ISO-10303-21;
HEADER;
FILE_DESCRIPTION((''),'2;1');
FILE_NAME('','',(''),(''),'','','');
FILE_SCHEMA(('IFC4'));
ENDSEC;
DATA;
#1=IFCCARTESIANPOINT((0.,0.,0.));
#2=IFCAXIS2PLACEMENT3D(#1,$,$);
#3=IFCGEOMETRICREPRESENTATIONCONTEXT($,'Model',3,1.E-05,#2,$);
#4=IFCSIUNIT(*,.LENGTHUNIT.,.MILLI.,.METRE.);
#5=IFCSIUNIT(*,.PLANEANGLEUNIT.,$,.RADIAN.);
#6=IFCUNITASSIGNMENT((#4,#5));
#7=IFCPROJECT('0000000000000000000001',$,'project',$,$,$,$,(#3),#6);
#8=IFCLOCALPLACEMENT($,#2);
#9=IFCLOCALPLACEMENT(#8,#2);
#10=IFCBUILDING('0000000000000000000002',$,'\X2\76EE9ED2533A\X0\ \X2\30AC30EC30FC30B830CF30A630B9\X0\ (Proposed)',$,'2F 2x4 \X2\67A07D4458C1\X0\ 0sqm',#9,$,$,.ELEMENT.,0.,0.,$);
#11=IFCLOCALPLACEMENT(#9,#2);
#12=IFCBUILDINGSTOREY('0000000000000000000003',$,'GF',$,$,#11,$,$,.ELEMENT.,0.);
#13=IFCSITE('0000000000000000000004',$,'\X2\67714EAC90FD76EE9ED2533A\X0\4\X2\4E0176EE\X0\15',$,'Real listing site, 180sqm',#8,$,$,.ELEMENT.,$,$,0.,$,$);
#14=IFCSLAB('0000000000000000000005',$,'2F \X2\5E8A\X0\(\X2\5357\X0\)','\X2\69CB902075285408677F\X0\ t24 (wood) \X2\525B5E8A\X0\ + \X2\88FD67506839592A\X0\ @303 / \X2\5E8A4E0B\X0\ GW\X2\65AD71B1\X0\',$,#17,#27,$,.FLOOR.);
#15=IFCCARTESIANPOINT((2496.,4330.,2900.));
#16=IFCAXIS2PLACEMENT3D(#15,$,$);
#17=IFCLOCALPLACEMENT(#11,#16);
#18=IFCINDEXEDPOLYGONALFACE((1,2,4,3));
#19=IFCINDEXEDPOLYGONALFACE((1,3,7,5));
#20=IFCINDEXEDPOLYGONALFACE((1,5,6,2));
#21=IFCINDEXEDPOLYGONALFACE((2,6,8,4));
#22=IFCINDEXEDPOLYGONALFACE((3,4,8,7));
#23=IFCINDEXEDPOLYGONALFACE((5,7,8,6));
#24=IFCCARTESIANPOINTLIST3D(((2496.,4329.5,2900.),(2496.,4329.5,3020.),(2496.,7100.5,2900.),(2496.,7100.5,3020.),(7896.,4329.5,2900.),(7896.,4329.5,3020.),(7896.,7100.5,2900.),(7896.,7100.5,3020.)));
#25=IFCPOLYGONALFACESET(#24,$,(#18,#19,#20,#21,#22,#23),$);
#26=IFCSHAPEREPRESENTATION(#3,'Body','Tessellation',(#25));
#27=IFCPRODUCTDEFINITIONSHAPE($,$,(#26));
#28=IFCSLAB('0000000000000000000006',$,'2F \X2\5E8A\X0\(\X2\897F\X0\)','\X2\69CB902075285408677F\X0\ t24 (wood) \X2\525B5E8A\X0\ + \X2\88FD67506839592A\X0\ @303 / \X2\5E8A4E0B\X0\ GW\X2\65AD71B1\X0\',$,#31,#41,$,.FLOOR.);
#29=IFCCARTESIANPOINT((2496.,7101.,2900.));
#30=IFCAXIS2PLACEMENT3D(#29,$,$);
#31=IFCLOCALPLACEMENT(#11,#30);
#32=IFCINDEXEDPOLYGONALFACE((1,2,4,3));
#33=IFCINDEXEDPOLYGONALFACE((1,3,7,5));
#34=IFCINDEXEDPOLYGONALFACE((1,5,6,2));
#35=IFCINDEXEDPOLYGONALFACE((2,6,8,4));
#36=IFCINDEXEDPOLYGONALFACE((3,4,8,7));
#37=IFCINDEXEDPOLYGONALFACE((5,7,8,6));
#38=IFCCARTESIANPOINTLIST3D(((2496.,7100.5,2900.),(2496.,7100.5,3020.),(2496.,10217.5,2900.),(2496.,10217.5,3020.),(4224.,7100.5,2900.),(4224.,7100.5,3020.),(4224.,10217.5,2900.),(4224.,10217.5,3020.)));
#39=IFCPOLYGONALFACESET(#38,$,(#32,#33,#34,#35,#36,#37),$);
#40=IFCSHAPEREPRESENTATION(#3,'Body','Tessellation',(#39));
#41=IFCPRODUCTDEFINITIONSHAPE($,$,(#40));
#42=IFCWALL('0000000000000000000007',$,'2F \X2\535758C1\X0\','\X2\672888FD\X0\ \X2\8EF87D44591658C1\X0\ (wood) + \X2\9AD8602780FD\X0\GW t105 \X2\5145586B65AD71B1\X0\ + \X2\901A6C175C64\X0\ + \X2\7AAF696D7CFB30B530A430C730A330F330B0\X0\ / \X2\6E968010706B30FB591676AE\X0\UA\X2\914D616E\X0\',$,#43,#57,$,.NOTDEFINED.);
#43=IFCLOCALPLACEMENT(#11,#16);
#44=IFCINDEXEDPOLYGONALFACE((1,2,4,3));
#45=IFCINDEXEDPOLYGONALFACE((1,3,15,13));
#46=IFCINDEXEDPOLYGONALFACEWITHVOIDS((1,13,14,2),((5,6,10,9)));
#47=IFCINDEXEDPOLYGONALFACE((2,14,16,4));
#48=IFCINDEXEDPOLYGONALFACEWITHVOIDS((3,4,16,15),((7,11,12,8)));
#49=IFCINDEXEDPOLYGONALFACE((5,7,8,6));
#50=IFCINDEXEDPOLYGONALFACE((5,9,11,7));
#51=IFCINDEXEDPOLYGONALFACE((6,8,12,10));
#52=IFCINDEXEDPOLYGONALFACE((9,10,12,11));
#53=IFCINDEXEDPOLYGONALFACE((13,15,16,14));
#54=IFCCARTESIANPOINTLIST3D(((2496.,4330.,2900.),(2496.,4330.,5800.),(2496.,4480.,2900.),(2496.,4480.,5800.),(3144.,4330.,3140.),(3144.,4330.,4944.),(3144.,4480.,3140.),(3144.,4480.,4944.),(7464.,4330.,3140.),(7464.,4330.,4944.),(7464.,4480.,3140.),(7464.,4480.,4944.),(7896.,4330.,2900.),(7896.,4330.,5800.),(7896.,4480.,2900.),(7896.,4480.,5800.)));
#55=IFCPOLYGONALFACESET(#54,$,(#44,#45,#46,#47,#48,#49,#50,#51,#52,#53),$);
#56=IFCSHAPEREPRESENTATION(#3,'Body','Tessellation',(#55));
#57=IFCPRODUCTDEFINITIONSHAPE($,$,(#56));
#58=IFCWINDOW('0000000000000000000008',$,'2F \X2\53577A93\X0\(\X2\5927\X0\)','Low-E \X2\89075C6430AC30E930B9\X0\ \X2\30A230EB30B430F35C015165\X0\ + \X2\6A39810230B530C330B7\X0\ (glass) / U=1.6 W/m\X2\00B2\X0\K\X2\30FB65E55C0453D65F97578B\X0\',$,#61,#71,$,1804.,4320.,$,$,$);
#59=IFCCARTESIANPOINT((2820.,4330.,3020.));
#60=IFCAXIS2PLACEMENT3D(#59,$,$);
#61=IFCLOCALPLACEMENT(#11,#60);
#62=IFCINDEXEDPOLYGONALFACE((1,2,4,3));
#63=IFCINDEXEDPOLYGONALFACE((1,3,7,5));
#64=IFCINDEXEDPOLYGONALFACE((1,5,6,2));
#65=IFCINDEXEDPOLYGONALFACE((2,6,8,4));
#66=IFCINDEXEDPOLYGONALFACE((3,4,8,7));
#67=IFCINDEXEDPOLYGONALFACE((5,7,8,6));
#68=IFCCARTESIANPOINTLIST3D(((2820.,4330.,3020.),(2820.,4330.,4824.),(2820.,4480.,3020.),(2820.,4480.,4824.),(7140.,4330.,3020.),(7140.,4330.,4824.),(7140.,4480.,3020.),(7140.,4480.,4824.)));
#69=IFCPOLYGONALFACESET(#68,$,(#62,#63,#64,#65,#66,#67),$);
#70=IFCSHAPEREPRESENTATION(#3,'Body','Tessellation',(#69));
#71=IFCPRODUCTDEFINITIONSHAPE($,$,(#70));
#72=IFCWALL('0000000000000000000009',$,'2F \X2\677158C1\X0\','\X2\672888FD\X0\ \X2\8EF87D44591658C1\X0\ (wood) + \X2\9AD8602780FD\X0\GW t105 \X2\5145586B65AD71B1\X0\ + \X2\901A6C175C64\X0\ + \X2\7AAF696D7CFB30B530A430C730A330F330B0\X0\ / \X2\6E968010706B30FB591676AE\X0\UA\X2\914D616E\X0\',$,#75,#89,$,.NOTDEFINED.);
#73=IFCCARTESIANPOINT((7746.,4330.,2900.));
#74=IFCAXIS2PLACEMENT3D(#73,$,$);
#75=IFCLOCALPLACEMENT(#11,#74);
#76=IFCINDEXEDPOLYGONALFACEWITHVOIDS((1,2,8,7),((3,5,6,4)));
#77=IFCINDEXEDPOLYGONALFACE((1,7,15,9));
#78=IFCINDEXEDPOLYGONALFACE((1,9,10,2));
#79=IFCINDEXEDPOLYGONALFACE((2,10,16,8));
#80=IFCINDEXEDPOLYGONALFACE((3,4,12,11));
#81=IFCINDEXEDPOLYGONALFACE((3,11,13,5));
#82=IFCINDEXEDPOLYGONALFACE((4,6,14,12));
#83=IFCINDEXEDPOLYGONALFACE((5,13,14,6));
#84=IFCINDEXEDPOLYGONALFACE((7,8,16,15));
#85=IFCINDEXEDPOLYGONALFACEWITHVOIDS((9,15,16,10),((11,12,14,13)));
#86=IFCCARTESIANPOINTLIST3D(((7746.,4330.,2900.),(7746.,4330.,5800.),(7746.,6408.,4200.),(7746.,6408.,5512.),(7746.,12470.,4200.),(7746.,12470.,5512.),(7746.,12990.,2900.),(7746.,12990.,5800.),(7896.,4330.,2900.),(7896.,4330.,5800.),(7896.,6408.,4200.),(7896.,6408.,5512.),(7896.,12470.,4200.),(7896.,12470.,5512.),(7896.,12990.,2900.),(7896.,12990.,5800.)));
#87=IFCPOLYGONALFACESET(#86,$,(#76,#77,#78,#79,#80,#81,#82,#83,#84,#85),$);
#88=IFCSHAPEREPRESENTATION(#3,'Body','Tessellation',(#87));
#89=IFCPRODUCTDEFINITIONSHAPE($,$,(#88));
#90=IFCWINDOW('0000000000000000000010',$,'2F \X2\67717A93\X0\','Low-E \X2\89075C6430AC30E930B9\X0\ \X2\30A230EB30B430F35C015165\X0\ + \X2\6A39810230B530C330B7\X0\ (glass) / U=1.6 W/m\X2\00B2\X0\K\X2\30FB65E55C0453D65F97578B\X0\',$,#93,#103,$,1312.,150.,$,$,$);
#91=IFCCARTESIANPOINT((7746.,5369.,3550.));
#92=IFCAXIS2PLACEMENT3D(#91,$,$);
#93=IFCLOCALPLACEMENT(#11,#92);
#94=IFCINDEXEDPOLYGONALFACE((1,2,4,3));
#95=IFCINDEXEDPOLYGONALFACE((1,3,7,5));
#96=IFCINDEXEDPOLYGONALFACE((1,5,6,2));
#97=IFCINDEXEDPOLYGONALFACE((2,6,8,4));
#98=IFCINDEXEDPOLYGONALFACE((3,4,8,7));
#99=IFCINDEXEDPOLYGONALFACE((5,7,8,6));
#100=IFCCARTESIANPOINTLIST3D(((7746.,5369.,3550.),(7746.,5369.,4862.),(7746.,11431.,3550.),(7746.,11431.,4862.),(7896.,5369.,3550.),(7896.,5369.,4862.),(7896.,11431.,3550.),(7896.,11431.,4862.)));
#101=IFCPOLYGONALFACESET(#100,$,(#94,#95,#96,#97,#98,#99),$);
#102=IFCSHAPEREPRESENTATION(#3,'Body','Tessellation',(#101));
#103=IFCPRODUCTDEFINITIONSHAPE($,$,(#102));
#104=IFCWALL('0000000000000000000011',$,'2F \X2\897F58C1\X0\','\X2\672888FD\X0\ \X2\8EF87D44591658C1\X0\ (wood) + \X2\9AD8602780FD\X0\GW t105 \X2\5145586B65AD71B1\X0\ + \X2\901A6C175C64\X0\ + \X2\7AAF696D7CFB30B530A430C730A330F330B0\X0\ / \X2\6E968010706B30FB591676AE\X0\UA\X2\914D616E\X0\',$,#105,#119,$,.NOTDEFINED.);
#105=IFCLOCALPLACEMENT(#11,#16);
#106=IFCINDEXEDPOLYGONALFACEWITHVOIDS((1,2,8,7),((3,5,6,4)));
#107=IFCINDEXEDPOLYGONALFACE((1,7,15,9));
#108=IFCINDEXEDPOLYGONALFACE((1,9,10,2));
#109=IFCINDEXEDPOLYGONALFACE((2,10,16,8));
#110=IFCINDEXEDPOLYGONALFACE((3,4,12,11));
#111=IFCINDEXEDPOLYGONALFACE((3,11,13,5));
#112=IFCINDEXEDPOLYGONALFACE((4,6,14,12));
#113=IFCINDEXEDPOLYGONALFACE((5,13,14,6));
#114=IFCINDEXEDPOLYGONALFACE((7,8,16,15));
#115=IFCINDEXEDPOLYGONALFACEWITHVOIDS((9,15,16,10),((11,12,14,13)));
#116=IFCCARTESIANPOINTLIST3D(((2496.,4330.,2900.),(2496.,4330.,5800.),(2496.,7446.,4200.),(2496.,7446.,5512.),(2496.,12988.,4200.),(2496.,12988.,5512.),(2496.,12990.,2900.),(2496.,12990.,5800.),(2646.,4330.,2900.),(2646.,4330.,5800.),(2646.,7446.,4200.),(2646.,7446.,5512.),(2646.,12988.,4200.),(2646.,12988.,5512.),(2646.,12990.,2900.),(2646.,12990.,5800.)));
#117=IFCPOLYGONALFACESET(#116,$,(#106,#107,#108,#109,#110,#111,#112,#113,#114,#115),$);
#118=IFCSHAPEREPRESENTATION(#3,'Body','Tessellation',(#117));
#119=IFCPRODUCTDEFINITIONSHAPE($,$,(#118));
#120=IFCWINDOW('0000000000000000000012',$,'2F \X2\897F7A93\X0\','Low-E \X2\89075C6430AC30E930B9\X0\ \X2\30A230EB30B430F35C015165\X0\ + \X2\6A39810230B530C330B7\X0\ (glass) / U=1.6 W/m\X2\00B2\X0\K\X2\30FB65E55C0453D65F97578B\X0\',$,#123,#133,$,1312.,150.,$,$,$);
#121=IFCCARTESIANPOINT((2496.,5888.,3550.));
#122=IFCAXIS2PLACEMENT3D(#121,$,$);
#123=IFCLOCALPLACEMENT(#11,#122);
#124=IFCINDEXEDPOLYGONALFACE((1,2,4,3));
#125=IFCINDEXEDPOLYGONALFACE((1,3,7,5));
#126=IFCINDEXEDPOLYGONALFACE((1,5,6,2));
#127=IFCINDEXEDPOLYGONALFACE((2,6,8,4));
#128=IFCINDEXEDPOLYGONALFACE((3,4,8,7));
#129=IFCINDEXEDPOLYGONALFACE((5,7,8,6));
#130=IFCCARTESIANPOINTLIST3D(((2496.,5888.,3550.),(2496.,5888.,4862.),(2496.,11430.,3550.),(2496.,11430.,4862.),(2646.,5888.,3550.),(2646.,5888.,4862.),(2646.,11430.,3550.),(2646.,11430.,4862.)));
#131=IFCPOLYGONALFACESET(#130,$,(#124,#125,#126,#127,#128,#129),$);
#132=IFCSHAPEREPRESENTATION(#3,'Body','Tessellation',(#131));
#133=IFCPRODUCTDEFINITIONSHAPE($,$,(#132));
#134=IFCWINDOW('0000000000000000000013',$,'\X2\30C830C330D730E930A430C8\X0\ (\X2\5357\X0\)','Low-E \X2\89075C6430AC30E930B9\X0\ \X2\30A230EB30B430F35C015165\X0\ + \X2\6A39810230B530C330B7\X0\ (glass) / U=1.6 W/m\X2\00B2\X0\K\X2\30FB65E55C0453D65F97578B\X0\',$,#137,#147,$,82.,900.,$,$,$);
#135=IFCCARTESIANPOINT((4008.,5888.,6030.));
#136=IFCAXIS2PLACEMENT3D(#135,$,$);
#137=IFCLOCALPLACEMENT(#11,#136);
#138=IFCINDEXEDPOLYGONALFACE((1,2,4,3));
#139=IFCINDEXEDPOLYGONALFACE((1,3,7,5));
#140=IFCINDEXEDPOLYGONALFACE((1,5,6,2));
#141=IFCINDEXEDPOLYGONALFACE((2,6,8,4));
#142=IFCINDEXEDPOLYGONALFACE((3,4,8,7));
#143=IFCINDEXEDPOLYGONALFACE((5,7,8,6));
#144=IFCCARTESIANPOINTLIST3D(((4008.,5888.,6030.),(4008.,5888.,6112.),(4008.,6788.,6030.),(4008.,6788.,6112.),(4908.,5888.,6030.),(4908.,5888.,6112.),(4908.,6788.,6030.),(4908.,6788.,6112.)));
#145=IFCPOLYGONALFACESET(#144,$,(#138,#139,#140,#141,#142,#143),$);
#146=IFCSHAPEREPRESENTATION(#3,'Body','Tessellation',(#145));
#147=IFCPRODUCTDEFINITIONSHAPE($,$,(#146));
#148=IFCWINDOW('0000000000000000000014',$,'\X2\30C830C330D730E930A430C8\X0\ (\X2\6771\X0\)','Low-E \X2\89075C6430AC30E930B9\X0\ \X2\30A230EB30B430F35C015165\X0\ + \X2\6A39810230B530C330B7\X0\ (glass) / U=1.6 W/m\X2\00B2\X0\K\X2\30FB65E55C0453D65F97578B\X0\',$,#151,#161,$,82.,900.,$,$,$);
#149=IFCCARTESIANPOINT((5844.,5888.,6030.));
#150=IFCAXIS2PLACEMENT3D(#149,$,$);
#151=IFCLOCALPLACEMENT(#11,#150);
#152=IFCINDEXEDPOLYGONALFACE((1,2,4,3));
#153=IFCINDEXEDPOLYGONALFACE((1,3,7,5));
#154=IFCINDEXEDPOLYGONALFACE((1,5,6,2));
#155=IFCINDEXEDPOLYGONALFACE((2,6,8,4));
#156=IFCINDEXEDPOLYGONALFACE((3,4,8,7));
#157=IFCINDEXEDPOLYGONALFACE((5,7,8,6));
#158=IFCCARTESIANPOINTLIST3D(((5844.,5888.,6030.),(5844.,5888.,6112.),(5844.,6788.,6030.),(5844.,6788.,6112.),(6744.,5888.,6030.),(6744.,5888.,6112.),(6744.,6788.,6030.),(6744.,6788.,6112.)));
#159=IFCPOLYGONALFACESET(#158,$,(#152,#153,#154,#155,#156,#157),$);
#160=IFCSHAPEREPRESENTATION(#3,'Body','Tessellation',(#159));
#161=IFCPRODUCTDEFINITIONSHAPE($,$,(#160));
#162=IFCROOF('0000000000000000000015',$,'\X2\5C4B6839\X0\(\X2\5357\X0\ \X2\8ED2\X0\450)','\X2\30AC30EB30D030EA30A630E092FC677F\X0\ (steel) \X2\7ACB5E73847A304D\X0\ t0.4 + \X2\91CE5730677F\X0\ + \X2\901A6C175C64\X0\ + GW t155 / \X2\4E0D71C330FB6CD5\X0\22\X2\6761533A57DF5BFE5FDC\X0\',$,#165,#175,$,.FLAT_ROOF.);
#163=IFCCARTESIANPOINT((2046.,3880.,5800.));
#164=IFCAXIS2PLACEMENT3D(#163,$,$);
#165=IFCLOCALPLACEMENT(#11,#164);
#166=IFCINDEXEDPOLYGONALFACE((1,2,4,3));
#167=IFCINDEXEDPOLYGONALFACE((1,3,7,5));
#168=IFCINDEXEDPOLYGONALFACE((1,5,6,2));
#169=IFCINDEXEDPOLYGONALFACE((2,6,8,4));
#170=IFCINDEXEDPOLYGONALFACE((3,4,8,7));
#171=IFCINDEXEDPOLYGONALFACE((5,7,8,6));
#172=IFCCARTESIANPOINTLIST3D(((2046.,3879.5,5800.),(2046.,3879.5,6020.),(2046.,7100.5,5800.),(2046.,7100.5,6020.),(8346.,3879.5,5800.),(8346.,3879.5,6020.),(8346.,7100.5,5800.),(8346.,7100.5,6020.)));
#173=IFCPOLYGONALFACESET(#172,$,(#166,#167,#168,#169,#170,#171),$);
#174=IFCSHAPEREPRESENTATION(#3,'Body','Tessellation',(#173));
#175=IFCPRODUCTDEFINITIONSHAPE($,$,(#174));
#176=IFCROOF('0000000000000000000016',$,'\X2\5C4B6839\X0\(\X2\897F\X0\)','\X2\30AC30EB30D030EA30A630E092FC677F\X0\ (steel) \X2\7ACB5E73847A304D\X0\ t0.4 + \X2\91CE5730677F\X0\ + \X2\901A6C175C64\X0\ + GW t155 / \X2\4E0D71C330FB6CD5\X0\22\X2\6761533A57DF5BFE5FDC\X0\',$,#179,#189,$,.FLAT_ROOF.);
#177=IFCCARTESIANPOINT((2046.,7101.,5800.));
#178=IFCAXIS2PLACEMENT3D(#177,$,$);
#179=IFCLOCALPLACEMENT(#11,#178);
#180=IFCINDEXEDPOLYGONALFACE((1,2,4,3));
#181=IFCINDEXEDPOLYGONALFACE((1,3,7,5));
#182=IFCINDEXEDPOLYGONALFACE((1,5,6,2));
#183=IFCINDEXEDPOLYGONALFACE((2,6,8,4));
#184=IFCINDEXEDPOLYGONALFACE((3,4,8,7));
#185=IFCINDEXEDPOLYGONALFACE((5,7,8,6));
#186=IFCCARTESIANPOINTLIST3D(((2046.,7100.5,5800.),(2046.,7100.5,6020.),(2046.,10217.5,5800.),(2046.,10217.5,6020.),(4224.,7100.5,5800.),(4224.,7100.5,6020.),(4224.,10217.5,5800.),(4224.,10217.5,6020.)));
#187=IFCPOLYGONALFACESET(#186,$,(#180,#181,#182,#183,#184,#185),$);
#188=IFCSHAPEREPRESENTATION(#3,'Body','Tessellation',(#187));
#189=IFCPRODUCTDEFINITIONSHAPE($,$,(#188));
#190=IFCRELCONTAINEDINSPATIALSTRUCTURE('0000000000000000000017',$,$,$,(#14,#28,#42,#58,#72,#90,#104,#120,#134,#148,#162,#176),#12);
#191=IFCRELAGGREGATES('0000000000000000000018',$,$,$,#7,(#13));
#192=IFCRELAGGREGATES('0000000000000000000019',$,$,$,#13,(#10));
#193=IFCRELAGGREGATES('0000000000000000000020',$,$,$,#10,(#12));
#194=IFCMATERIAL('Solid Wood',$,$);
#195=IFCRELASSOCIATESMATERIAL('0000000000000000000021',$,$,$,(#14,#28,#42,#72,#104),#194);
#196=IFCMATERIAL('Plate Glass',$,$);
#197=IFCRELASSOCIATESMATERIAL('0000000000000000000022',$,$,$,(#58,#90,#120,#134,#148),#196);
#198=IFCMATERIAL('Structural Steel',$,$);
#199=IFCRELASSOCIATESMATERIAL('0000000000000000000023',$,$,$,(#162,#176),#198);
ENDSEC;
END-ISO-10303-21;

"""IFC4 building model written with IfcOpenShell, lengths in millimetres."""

from ifc_helpers import new_model, si_unit, frame, frame_2d, origin, place, context, project, spatial, rectangle, extrude, material, element, fill, save


model = new_model("IFC4")

# Units and contexts
model_context = context("Model", 3, precision=1e-05, world=origin())
ifc_project = project(units=[si_unit("LENGTHUNIT", "METRE", prefix="MILLI"), si_unit("PLANEANGLEUNIT", "RADIAN")], contexts=[model_context])

# Site, building, storey
site_placement = place(None, origin())
site = spatial("IfcSite", under=ifc_project, at=site_placement, Name="東京都目黒区4丁目15", ObjectType="Real listing site, 180sqm", CompositionType="ELEMENT", RefElevation=0.0)
building_placement = place(site_placement, origin())
building = spatial("IfcBuilding", under=site, at=building_placement, Name="目黒区 ガレージハウス (Proposed)", ObjectType="2F 2x4 枠組壁 0sqm", CompositionType="ELEMENT", ElevationOfRefHeight=0.0, ElevationOfTerrain=0.0)
storey_placement = place(building_placement, origin())
storey = spatial("IfcBuildingStorey", under=building, at=storey_placement, Name="GF", CompositionType="ELEMENT", Elevation=0.0)

# Slabs
ifc_material_1 = material(Name="Solid Wood")
slab_1_placement = place(storey_placement, frame((2496.0, 4330.0, 2900.0)))
element("IfcSlab", 1, at=slab_1_placement, inside=storey, material=ifc_material_1, Name="2F 床(南)", Description="構造用合板 t24 (wood) 剛床 + 製材根太 @303 / 床下 GW断熱", PredefinedType="FLOOR", context=model_context, shape_type="SweptSolid", body=[
    extrude(rectangle(XDim=5400.0, YDim=2771.0, at=frame_2d((2700.0, 1385.0))), frame((2496.0, 4330.0, 2900.0)), (0.0, 0.0, 1.0), 120.0),
])
slab_2_placement = place(storey_placement, frame((2496.0, 7101.0, 2900.0)))
element("IfcSlab", 2, at=slab_2_placement, inside=storey, material=ifc_material_1, Name="2F 床(西)", Description="構造用合板 t24 (wood) 剛床 + 製材根太 @303 / 床下 GW断熱", PredefinedType="FLOOR", context=model_context, shape_type="SweptSolid", body=[
    extrude(rectangle(XDim=1728.0, YDim=3117.0, at=frame_2d((864.0, 1558.0))), frame((2496.0, 7101.0, 2900.0)), (0.0, 0.0, 1.0), 120.0),
])

# Walls, openings, windows
wall_1_placement = place(storey_placement, frame((2496.0, 4330.0, 2900.0)))
wall_1 = element("IfcWall", 3, at=wall_1_placement, inside=storey, material=ifc_material_1, Name="2F 南壁", Description="木製 軸組外壁 (wood) + 高性能GW t105 充填断熱 + 通気層 + 窯業系サイディング / 準耐火・外皮UA配慮", PredefinedType="NOTDEFINED", context=model_context, shape_type="SweptSolid", body=[
    extrude(rectangle(XDim=5400.0, YDim=150.0, at=frame_2d((2700.0, 75.0))), frame((2496.0, 4330.0, 2900.0)), (0.0, 0.0, 1.0), 2900.0),
])
opening_1_placement = place(storey_placement, frame((2820.0, 4330.0, 3020.0)))
opening_1 = element("IfcOpeningElement", 4, at=opening_1_placement, cuts=wall_1, PredefinedType="NOTDEFINED", context=model_context, shape_type="SweptSolid", body=[
    extrude(rectangle(XDim=4320.0, YDim=150.0, at=frame_2d((2160.0, 75.0))), frame((2820.0, 4330.0, 3020.0)), (0.0, 0.0, 1.0), 1804.0),
])
ifc_material_2 = material(Name="Plate Glass")
window_1_placement = place(storey_placement, frame((2820.0, 4330.0, 3020.0)))
window_1 = element("IfcWindow", 5, at=window_1_placement, inside=storey, material=ifc_material_2, Name="2F 南窓(大)", Description="Low-E 複層ガラス アルゴン封入 + 樹脂サッシ (glass) / U=1.6 W/m²K・日射取得型", OverallHeight=1804.0, OverallWidth=4320.0, context=model_context, shape_type="SweptSolid", body=[
    extrude(rectangle(XDim=4320.0, YDim=150.0, at=frame_2d((2160.0, 75.0))), frame((2820.0, 4330.0, 3020.0)), (0.0, 0.0, 1.0), 1804.0),
])
fill(opening_1, window_1)
wall_2_placement = place(storey_placement, frame((7746.0, 4330.0, 2900.0)))
wall_2 = element("IfcWall", 6, at=wall_2_placement, inside=storey, material=ifc_material_1, Name="2F 東壁", Description="木製 軸組外壁 (wood) + 高性能GW t105 充填断熱 + 通気層 + 窯業系サイディング / 準耐火・外皮UA配慮", PredefinedType="NOTDEFINED", context=model_context, shape_type="SweptSolid", body=[
    extrude(rectangle(XDim=150.0, YDim=8660.0, at=frame_2d((75.0, 4330.0))), frame((7746.0, 4330.0, 2900.0)), (0.0, 0.0, 1.0), 2900.0),
])
opening_2_placement = place(storey_placement, frame((7746.0, 5369.0, 3550.0)))
opening_2 = element("IfcOpeningElement", 7, at=opening_2_placement, cuts=wall_2, PredefinedType="NOTDEFINED", context=model_context, shape_type="SweptSolid", body=[
    extrude(rectangle(XDim=150.0, YDim=6062.0, at=frame_2d((75.0, 3031.0))), frame((7746.0, 5369.0, 3550.0)), (0.0, 0.0, 1.0), 1312.0),
])
window_2_placement = place(storey_placement, frame((7746.0, 5369.0, 3550.0)))
window_2 = element("IfcWindow", 8, at=window_2_placement, inside=storey, material=ifc_material_2, Name="2F 東窓", Description="Low-E 複層ガラス アルゴン封入 + 樹脂サッシ (glass) / U=1.6 W/m²K・日射取得型", OverallHeight=1312.0, OverallWidth=150.0, context=model_context, shape_type="SweptSolid", body=[
    extrude(rectangle(XDim=150.0, YDim=6062.0, at=frame_2d((75.0, 3031.0))), frame((7746.0, 5369.0, 3550.0)), (0.0, 0.0, 1.0), 1312.0),
])
fill(opening_2, window_2)
wall_3_placement = place(storey_placement, frame((2496.0, 4330.0, 2900.0)))
wall_3 = element("IfcWall", 9, at=wall_3_placement, inside=storey, material=ifc_material_1, Name="2F 西壁", Description="木製 軸組外壁 (wood) + 高性能GW t105 充填断熱 + 通気層 + 窯業系サイディング / 準耐火・外皮UA配慮", PredefinedType="NOTDEFINED", context=model_context, shape_type="SweptSolid", body=[
    extrude(rectangle(XDim=150.0, YDim=8660.0, at=frame_2d((75.0, 4330.0))), frame((2496.0, 4330.0, 2900.0)), (0.0, 0.0, 1.0), 2900.0),
])
opening_3_placement = place(storey_placement, frame((2496.0, 5888.0, 3550.0)))
opening_3 = element("IfcOpeningElement", 10, at=opening_3_placement, cuts=wall_3, PredefinedType="NOTDEFINED", context=model_context, shape_type="SweptSolid", body=[
    extrude(rectangle(XDim=150.0, YDim=5542.0, at=frame_2d((75.0, 2771.0))), frame((2496.0, 5888.0, 3550.0)), (0.0, 0.0, 1.0), 1312.0),
])
window_3_placement = place(storey_placement, frame((2496.0, 5888.0, 3550.0)))
window_3 = element("IfcWindow", 11, at=window_3_placement, inside=storey, material=ifc_material_2, Name="2F 西窓", Description="Low-E 複層ガラス アルゴン封入 + 樹脂サッシ (glass) / U=1.6 W/m²K・日射取得型", OverallHeight=1312.0, OverallWidth=150.0, context=model_context, shape_type="SweptSolid", body=[
    extrude(rectangle(XDim=150.0, YDim=5542.0, at=frame_2d((75.0, 2771.0))), frame((2496.0, 5888.0, 3550.0)), (0.0, 0.0, 1.0), 1312.0),
])
fill(opening_3, window_3)

# Windows
window_4_placement = place(storey_placement, frame((4008.0, 5888.0, 6030.0)))
element("IfcWindow", 12, at=window_4_placement, inside=storey, material=ifc_material_2, Name="トップライト (南)", Description="Low-E 複層ガラス アルゴン封入 + 樹脂サッシ (glass) / U=1.6 W/m²K・日射取得型", OverallHeight=82.0, OverallWidth=900.0, context=model_context, shape_type="SweptSolid", body=[
    extrude(rectangle(XDim=900.0, YDim=900.0, at=frame_2d((450.0, 450.0))), frame((4008.0, 5888.0, 6030.0)), (0.0, 0.0, 1.0), 82.0),
])
window_5_placement = place(storey_placement, frame((5844.0, 5888.0, 6030.0)))
element("IfcWindow", 13, at=window_5_placement, inside=storey, material=ifc_material_2, Name="トップライト (東)", Description="Low-E 複層ガラス アルゴン封入 + 樹脂サッシ (glass) / U=1.6 W/m²K・日射取得型", OverallHeight=82.0, OverallWidth=900.0, context=model_context, shape_type="SweptSolid", body=[
    extrude(rectangle(XDim=900.0, YDim=900.0, at=frame_2d((450.0, 450.0))), frame((5844.0, 5888.0, 6030.0)), (0.0, 0.0, 1.0), 82.0),
])

# Roofs
ifc_material_3 = material(Name="Structural Steel")
roof_1_placement = place(storey_placement, frame((2046.0, 3880.0, 5800.0)))
element("IfcRoof", 14, at=roof_1_placement, inside=storey, material=ifc_material_3, Name="屋根(南 軒450)", Description="ガルバリウム鋼板 (steel) 立平葺き t0.4 + 野地板 + 通気層 + GW t155 / 不燃・法22条区域対応", PredefinedType="FLAT_ROOF", context=model_context, shape_type="SweptSolid", body=[
    extrude(rectangle(XDim=6300.0, YDim=3221.0, at=frame_2d((3150.0, 1610.0))), frame((2046.0, 3880.0, 5800.0)), (0.0, 0.0, 1.0), 220.0),
])
roof_2_placement = place(storey_placement, frame((2046.0, 7101.0, 5800.0)))
element("IfcRoof", 15, at=roof_2_placement, inside=storey, material=ifc_material_3, Name="屋根(西)", Description="ガルバリウム鋼板 (steel) 立平葺き t0.4 + 野地板 + 通気層 + GW t155 / 不燃・法22条区域対応", PredefinedType="FLAT_ROOF", context=model_context, shape_type="SweptSolid", body=[
    extrude(rectangle(XDim=2178.0, YDim=3117.0, at=frame_2d((1089.0, 1558.0))), frame((2046.0, 7101.0, 5800.0)), (0.0, 0.0, 1.0), 220.0),
])

save(model, "model.ifc")
